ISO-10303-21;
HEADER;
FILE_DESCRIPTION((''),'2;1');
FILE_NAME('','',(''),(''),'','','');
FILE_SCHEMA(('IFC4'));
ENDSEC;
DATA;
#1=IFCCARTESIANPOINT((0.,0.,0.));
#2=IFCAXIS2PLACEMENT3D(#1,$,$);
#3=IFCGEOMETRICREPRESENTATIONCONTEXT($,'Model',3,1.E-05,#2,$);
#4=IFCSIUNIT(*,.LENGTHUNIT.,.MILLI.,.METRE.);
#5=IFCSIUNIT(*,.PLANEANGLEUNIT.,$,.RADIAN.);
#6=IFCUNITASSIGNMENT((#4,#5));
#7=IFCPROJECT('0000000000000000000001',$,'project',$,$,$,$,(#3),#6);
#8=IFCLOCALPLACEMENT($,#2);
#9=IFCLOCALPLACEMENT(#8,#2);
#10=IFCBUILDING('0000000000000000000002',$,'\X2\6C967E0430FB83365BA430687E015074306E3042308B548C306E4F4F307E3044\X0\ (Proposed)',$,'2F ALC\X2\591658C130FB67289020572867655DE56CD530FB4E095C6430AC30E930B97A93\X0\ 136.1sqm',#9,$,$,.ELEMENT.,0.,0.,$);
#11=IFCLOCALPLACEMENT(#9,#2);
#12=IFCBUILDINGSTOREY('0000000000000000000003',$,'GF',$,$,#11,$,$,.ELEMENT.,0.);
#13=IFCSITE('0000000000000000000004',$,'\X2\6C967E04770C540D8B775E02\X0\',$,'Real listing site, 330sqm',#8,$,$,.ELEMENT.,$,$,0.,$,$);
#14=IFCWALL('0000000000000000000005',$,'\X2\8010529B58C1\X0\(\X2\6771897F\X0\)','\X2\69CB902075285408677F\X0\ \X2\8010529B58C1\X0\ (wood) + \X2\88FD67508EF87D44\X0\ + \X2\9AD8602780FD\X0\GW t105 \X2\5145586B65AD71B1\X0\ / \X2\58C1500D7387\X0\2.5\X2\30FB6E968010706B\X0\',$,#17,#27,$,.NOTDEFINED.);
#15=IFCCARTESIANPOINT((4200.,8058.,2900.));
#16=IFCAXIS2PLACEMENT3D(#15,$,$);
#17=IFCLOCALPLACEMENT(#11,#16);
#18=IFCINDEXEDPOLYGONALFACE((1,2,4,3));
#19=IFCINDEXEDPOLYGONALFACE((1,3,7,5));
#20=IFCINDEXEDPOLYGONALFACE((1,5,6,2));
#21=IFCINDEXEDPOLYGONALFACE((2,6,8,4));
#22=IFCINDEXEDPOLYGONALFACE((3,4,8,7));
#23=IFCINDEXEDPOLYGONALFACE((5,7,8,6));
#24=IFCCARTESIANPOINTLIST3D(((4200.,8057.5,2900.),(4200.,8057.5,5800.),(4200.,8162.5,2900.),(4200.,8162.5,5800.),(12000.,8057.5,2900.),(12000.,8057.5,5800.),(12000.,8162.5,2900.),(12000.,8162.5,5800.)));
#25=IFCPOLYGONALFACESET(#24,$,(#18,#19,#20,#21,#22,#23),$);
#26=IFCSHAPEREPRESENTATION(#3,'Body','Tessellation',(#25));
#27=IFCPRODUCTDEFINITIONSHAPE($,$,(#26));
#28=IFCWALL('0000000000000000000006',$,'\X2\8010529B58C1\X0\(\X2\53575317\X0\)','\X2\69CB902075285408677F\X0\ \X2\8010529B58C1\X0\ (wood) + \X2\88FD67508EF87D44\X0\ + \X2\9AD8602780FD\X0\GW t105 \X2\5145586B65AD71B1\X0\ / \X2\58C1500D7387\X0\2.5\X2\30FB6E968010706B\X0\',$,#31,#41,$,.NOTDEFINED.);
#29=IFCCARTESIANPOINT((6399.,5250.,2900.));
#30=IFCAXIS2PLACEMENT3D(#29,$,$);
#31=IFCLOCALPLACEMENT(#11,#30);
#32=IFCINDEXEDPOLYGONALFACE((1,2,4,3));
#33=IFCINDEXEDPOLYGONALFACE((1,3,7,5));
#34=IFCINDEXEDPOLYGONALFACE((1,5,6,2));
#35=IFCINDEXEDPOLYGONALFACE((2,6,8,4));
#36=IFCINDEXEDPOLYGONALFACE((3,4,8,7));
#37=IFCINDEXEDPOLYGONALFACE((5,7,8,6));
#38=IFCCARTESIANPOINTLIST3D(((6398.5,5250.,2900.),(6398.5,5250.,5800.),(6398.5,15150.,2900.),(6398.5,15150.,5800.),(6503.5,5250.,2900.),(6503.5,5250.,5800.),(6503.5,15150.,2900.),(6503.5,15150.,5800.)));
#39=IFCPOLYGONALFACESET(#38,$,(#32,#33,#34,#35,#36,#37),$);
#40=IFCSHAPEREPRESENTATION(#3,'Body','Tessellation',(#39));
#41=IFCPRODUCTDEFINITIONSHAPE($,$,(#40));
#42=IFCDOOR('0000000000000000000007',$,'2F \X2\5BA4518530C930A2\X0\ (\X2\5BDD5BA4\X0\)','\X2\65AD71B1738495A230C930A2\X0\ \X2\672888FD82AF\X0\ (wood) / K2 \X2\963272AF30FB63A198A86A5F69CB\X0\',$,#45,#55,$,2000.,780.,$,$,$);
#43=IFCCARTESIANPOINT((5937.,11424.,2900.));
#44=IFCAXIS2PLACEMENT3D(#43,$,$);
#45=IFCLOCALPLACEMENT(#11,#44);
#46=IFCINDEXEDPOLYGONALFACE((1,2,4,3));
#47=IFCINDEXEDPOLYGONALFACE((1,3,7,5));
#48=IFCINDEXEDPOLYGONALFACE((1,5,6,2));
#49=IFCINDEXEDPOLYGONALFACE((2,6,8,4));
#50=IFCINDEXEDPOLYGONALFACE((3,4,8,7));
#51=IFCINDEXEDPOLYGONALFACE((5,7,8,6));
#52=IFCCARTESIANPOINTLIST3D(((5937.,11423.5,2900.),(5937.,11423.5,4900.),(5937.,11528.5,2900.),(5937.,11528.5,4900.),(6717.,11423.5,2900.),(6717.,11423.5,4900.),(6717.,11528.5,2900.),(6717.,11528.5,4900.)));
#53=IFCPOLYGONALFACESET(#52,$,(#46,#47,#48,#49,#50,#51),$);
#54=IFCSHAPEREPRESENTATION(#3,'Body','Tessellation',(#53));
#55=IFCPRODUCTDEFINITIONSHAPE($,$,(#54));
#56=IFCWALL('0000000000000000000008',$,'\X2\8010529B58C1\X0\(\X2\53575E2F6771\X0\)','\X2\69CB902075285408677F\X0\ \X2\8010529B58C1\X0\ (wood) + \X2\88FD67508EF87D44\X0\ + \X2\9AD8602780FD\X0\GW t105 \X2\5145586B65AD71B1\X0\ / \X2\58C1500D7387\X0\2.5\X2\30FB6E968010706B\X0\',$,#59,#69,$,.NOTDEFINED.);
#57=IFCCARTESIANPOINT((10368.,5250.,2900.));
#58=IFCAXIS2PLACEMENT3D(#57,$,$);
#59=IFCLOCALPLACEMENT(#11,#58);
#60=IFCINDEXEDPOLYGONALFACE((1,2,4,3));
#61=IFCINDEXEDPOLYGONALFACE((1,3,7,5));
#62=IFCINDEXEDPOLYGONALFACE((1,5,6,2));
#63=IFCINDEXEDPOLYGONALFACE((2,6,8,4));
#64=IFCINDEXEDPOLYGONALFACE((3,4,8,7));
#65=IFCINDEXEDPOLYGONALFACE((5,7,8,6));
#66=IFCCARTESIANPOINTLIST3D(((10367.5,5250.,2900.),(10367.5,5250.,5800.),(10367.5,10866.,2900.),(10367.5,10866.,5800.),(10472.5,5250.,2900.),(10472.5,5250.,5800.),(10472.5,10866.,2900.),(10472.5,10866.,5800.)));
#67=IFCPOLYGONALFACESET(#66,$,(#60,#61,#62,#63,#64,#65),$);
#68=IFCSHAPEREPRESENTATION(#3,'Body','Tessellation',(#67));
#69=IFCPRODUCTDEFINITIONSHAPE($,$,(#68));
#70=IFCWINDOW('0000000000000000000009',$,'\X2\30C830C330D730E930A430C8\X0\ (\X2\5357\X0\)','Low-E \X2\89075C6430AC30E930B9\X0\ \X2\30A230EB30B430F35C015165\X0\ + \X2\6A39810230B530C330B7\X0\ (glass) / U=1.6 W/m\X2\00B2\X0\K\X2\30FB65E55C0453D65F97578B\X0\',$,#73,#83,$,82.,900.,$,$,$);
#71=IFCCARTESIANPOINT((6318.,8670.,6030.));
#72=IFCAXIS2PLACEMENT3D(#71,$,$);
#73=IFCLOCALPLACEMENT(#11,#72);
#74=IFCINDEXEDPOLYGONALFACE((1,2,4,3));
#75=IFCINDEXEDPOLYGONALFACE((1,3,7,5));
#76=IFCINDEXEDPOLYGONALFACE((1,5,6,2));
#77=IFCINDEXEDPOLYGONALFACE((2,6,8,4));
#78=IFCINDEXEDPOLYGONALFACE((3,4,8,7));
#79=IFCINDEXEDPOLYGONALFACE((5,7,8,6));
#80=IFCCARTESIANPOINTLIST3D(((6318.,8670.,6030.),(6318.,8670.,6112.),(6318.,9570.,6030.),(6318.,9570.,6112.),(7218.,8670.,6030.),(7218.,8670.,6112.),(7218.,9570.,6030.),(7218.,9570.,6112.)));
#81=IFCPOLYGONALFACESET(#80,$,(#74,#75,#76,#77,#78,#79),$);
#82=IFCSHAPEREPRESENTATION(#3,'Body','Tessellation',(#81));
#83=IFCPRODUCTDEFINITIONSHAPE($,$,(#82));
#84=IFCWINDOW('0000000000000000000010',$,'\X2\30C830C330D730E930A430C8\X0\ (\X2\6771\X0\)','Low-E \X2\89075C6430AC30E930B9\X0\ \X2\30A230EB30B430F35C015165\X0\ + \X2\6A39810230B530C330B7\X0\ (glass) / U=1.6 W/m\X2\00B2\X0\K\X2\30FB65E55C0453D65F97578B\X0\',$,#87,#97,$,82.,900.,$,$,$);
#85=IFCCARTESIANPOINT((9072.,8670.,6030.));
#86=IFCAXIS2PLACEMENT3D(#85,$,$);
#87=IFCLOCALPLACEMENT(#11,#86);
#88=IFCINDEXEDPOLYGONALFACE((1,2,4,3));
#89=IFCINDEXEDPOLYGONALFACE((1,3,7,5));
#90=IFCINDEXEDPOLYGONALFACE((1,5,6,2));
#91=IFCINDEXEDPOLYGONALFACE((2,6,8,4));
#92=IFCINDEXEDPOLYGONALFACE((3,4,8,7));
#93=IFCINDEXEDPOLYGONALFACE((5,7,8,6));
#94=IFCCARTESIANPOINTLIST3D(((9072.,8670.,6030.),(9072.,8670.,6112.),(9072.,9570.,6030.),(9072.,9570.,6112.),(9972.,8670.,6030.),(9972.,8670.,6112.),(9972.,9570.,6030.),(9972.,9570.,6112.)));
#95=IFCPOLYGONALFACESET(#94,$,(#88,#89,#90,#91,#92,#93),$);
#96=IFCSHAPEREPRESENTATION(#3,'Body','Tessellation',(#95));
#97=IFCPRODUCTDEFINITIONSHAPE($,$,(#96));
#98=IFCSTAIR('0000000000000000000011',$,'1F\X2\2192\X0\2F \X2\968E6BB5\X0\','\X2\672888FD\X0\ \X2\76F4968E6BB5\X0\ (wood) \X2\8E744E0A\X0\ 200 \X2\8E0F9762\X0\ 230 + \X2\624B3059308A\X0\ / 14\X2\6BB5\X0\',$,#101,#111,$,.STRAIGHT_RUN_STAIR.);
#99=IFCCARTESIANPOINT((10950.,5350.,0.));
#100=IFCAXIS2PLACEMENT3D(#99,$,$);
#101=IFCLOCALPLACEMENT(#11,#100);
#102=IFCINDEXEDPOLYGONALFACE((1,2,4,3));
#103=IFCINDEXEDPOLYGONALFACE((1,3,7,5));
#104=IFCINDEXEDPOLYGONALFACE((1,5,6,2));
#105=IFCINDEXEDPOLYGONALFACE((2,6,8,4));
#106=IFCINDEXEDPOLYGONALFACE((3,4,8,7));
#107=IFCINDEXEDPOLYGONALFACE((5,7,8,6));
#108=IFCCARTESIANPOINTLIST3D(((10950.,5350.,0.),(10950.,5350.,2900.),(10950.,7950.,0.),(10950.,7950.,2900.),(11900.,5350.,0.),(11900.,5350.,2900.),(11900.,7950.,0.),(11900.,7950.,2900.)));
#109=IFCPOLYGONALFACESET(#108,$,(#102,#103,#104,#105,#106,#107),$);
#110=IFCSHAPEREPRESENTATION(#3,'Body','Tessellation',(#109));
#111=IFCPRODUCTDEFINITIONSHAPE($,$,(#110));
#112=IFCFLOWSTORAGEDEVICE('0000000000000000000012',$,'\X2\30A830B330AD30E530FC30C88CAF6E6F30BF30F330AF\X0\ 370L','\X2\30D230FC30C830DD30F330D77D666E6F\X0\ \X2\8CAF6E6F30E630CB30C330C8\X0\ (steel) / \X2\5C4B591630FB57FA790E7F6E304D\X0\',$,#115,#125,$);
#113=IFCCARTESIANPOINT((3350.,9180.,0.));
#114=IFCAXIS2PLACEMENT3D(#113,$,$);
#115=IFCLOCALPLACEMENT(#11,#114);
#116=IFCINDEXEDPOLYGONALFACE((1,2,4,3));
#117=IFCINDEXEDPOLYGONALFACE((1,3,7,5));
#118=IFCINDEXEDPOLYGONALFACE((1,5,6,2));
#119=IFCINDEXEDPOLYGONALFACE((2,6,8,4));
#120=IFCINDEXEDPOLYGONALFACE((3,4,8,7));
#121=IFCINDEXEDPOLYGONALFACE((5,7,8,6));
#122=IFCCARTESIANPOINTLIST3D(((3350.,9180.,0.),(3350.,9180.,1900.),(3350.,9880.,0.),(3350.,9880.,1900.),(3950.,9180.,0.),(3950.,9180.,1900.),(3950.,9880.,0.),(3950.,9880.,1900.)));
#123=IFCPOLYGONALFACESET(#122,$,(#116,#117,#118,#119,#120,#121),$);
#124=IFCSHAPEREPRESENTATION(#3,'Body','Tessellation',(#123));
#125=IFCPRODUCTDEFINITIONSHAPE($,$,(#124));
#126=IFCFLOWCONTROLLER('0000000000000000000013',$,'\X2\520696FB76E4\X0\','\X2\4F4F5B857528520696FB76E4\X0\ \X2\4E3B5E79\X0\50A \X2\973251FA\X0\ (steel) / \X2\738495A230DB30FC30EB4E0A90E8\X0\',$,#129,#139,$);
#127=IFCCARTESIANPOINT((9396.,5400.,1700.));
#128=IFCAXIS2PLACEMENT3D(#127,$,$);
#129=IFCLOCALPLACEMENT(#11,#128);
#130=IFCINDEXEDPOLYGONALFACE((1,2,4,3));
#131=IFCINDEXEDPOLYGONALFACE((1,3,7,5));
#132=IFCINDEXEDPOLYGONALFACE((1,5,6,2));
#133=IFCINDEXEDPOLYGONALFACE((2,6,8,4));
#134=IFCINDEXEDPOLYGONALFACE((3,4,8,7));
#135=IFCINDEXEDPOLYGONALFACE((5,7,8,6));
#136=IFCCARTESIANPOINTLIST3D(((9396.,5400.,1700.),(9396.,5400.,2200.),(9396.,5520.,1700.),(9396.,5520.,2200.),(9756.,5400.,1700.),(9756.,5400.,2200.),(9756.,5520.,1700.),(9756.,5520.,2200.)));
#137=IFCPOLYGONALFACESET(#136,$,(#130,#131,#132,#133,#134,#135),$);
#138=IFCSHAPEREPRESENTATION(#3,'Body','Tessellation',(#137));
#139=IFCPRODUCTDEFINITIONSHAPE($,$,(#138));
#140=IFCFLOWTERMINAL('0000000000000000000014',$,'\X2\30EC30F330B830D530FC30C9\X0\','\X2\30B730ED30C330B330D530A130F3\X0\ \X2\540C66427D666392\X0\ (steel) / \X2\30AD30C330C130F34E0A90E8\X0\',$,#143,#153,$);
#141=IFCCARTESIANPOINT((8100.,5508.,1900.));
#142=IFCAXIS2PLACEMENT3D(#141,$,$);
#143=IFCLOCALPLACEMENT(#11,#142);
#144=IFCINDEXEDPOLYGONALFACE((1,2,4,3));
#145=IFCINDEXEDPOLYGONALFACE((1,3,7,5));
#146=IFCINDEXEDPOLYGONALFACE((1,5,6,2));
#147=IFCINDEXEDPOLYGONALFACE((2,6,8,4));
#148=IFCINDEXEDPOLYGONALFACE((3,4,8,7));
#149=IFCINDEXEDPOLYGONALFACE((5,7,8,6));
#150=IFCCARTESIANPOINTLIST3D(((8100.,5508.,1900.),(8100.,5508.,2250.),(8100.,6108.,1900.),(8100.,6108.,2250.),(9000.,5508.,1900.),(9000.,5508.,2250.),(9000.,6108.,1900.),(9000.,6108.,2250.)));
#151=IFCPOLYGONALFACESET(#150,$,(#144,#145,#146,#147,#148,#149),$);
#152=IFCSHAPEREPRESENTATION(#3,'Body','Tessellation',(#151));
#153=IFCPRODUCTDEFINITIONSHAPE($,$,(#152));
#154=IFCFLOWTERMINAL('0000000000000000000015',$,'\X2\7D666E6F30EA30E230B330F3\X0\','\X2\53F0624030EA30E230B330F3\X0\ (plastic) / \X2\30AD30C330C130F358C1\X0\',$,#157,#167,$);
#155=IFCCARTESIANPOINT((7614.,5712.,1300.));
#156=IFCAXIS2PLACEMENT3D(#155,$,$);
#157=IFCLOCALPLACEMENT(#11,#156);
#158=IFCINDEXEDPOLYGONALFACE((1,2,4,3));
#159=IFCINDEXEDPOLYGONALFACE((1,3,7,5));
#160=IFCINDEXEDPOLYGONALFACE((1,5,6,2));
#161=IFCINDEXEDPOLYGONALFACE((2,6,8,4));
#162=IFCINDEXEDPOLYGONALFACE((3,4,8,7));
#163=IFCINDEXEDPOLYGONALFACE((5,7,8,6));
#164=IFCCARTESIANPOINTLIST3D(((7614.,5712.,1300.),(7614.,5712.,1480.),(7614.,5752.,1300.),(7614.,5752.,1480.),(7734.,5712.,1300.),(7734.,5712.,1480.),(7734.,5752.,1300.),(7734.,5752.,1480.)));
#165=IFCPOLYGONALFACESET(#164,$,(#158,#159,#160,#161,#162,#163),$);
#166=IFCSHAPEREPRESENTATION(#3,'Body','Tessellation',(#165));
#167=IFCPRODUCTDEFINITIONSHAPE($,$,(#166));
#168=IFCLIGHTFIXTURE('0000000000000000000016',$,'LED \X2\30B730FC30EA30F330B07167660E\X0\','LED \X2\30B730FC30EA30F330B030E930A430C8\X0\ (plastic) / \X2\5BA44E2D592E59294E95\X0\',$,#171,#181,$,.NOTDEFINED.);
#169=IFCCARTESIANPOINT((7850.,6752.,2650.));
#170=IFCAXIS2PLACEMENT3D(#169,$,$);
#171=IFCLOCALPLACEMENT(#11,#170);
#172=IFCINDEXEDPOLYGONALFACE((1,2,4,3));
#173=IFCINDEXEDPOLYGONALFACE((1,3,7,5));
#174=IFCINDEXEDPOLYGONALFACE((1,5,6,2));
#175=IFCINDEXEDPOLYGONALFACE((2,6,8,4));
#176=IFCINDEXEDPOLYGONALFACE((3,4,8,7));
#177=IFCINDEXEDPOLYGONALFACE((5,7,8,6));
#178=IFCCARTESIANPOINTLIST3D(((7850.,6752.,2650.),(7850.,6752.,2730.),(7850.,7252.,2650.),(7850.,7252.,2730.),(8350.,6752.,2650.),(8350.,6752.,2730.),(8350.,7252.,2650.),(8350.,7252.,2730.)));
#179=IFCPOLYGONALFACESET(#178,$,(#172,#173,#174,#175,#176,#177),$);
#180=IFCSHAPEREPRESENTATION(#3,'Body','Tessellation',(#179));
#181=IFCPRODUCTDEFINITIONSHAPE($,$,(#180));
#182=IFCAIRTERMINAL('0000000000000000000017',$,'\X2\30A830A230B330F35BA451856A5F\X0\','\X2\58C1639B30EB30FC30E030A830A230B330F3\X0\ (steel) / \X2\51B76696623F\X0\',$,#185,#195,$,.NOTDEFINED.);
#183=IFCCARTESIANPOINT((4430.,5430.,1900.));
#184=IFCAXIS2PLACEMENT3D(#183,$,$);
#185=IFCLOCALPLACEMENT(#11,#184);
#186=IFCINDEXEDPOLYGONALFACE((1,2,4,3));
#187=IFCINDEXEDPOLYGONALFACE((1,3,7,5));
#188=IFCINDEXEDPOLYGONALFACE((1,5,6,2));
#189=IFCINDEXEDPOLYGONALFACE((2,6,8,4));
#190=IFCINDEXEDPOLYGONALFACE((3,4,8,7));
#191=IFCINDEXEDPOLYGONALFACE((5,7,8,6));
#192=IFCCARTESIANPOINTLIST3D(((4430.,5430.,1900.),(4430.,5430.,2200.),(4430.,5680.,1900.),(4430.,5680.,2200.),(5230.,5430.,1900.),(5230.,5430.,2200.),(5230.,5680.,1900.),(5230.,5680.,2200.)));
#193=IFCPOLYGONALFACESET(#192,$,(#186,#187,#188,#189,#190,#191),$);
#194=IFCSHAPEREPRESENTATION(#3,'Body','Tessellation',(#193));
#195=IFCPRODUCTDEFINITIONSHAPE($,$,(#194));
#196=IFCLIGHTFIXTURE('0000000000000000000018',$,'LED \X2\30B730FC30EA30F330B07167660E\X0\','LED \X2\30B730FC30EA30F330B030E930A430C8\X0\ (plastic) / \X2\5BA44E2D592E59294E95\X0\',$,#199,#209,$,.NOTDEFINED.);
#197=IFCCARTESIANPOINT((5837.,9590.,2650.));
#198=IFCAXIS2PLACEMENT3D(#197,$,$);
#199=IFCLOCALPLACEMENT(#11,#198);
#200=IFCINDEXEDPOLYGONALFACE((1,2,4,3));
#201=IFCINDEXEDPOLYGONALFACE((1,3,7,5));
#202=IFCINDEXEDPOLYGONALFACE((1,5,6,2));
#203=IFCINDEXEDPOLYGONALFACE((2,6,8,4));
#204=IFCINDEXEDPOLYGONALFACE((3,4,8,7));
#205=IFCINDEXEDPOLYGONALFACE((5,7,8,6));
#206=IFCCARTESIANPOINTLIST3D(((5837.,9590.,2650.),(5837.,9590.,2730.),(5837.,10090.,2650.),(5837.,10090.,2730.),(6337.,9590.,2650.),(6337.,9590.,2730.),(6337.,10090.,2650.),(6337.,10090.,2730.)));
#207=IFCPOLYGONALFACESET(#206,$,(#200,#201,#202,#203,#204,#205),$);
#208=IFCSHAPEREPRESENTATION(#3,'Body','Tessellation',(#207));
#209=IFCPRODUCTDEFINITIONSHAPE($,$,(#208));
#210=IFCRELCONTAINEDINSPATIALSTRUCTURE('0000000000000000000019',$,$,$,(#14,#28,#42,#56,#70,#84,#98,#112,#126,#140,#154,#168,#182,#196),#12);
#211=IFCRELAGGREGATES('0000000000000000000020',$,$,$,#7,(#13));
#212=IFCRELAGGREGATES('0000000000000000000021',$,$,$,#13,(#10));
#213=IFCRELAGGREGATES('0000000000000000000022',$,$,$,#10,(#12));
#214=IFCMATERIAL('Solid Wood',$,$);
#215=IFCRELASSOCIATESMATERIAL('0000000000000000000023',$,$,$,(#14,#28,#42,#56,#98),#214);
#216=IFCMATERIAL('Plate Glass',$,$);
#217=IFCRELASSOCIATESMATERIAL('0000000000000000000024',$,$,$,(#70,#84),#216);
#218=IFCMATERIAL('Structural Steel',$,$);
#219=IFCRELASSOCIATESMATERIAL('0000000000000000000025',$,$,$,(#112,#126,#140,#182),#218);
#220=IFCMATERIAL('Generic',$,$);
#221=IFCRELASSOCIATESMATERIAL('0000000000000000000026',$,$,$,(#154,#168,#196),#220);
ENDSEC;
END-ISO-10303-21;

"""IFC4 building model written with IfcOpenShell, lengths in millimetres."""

from ifc_helpers import new_model, si_unit, frame, frame_2d, origin, place, context, project, spatial, rectangle, extrude, material, element, fill, save


model = new_model("IFC4")

# Units and contexts
model_context = context("Model", 3, precision=1e-05, world=origin())
ifc_project = project(units=[si_unit("LENGTHUNIT", "METRE", prefix="MILLI"), si_unit("PLANEANGLEUNIT", "RADIAN")], contexts=[model_context])

# Site, building, storey
site_placement = place(None, origin())
site = spatial("IfcSite", under=ifc_project, at=site_placement, Name="沖縄県名護市", ObjectType="Real listing site, 330sqm", CompositionType="ELEMENT", RefElevation=0.0)
building_placement = place(site_placement, origin())
building = spatial("IfcBuilding", under=site, at=building_placement, Name="沖縄・茶室と縁側のある和の住まい (Proposed)", ObjectType="2F ALC外壁・木造在来工法・三層ガラス窓 136.1sqm", CompositionType="ELEMENT", ElevationOfRefHeight=0.0, ElevationOfTerrain=0.0)
storey_placement = place(building_placement, origin())
storey = spatial("IfcBuildingStorey", under=building, at=storey_placement, Name="GF", CompositionType="ELEMENT", Elevation=0.0)

# Shared definitions
ifc_material_1 = material(Name="Solid Wood")

# Wall
wall_1_placement = place(storey_placement, frame((4200.0, 8058.0, 2900.0)))
element("IfcWall", 1, at=wall_1_placement, inside=storey, material=ifc_material_1, Name="耐力壁(東西)", Description="構造用合板 耐力壁 (wood) + 製材軸組 + 高性能GW t105 充填断熱 / 壁倍率2.5・準耐火", PredefinedType="NOTDEFINED", context=model_context, shape_type="SweptSolid", body=[
    extrude(rectangle(XDim=7800.0, YDim=105.0, at=frame_2d((3900.0, 52.0))), frame((4200.0, 8058.0, 2900.0)), (0.0, 0.0, 1.0), 2900.0),
])

# Wall, opening, door
wall_2_placement = place(storey_placement, frame((6399.0, 5250.0, 2900.0)))
wall_2 = element("IfcWall", 2, at=wall_2_placement, inside=storey, material=ifc_material_1, Name="耐力壁(南北)", Description="構造用合板 耐力壁 (wood) + 製材軸組 + 高性能GW t105 充填断熱 / 壁倍率2.5・準耐火", PredefinedType="NOTDEFINED", context=model_context, shape_type="SweptSolid", body=[
    extrude(rectangle(XDim=105.0, YDim=9900.0, at=frame_2d((52.0, 4950.0))), frame((6399.0, 5250.0, 2900.0)), (0.0, 0.0, 1.0), 2900.0),
])
opening_placement = place(storey_placement, frame((5937.0, 11424.0, 2900.0)))
opening = element("IfcOpeningElement", 3, at=opening_placement, cuts=wall_2, PredefinedType="NOTDEFINED", context=model_context, shape_type="SweptSolid", body=[
    extrude(rectangle(XDim=780.0, YDim=105.0, at=frame_2d((390.0, 52.0))), frame((5937.0, 11424.0, 2900.0)), (0.0, 0.0, 1.0), 2000.0),
])
door_placement = place(storey_placement, frame((5937.0, 11424.0, 2900.0)))
door = element("IfcDoor", 4, at=door_placement, inside=storey, material=ifc_material_1, Name="2F 室内ドア (寝室)", Description="断熱玄関ドア 木製芯 (wood) / K2 防犯・採風機構", OverallHeight=2000.0, OverallWidth=780.0, context=model_context, shape_type="SweptSolid", body=[
    extrude(rectangle(XDim=780.0, YDim=105.0, at=frame_2d((390.0, 52.0))), frame((5937.0, 11424.0, 2900.0)), (0.0, 0.0, 1.0), 2000.0),
])
fill(opening, door)

# Wall
wall_3_placement = place(storey_placement, frame((10368.0, 5250.0, 2900.0)))
element("IfcWall", 5, at=wall_3_placement, inside=storey, material=ifc_material_1, Name="耐力壁(南帯東)", Description="構造用合板 耐力壁 (wood) + 製材軸組 + 高性能GW t105 充填断熱 / 壁倍率2.5・準耐火", PredefinedType="NOTDEFINED", context=model_context, shape_type="SweptSolid", body=[
    extrude(rectangle(XDim=105.0, YDim=5616.0, at=frame_2d((52.0, 2808.0))), frame((10368.0, 5250.0, 2900.0)), (0.0, 0.0, 1.0), 2900.0),
])

# Windows
ifc_material_2 = material(Name="Plate Glass")
window_1_placement = place(storey_placement, frame((6318.0, 8670.0, 6030.0)))
element("IfcWindow", 6, at=window_1_placement, inside=storey, material=ifc_material_2, Name="トップライト (南)", Description="Low-E 複層ガラス アルゴン封入 + 樹脂サッシ (glass) / U=1.6 W/m²K・日射取得型", OverallHeight=82.0, OverallWidth=900.0, context=model_context, shape_type="SweptSolid", body=[
    extrude(rectangle(XDim=900.0, YDim=900.0, at=frame_2d((450.0, 450.0))), frame((6318.0, 8670.0, 6030.0)), (0.0, 0.0, 1.0), 82.0),
])
window_2_placement = place(storey_placement, frame((9072.0, 8670.0, 6030.0)))
element("IfcWindow", 7, at=window_2_placement, inside=storey, material=ifc_material_2, Name="トップライト (東)", Description="Low-E 複層ガラス アルゴン封入 + 樹脂サッシ (glass) / U=1.6 W/m²K・日射取得型", OverallHeight=82.0, OverallWidth=900.0, context=model_context, shape_type="SweptSolid", body=[
    extrude(rectangle(XDim=900.0, YDim=900.0, at=frame_2d((450.0, 450.0))), frame((9072.0, 8670.0, 6030.0)), (0.0, 0.0, 1.0), 82.0),
])

# Stair
stair_placement = place(storey_placement, frame((10950.0, 5350.0, 0.0)))
element("IfcStair", 8, at=stair_placement, inside=storey, material=ifc_material_1, Name="1F→2F 階段", Description="木製 直階段 (wood) 蹴上 200 踏面 230 + 手すり / 14段", PredefinedType="STRAIGHT_RUN_STAIR", context=model_context, shape_type="SweptSolid", body=[
    extrude(rectangle(XDim=950.0, YDim=2600.0, at=frame_2d((475.0, 1300.0))), frame((10950.0, 5350.0, 0.0)), (0.0, 0.0, 1.0), 2900.0),
])

# Flow storage device
ifc_material_3 = material(Name="Structural Steel")
flow_storage_device_placement = place(storey_placement, frame((3350.0, 9180.0, 0.0)))
element("IfcFlowStorageDevice", 9, at=flow_storage_device_placement, inside=storey, material=ifc_material_3, Name="エコキュート貯湯タンク 370L", Description="ヒートポンプ給湯 貯湯ユニット (steel) / 屋外・基礎置き", context=model_context, shape_type="SweptSolid", body=[
    extrude(rectangle(XDim=600.0, YDim=700.0, at=frame_2d((300.0, 350.0))), frame((3350.0, 9180.0, 0.0)), (0.0, 0.0, 1.0), 1900.0),
])

# Flow controller
flow_controller_placement = place(storey_placement, frame((9396.0, 5400.0, 1700.0)))
element("IfcFlowController", 10, at=flow_controller_placement, inside=storey, material=ifc_material_3, Name="分電盤", Description="住宅用分電盤 主幹50A 露出 (steel) / 玄関ホール上部", context=model_context, shape_type="SweptSolid", body=[
    extrude(rectangle(XDim=360.0, YDim=120.0, at=frame_2d((180.0, 60.0))), frame((9396.0, 5400.0, 1700.0)), (0.0, 0.0, 1.0), 500.0),
])

# Flow terminals
flow_terminal_1_placement = place(storey_placement, frame((8100.0, 5508.0, 1900.0)))
element("IfcFlowTerminal", 11, at=flow_terminal_1_placement, inside=storey, material=ifc_material_3, Name="レンジフード", Description="シロッコファン 同時給排 (steel) / キッチン上部", context=model_context, shape_type="SweptSolid", body=[
    extrude(rectangle(XDim=900.0, YDim=600.0, at=frame_2d((450.0, 300.0))), frame((8100.0, 5508.0, 1900.0)), (0.0, 0.0, 1.0), 350.0),
])
ifc_material_4 = material(Name="Generic")
flow_terminal_2_placement = place(storey_placement, frame((7614.0, 5712.0, 1300.0)))
element("IfcFlowTerminal", 12, at=flow_terminal_2_placement, inside=storey, material=ifc_material_4, Name="給湯リモコン", Description="台所リモコン (plastic) / キッチン壁", context=model_context, shape_type="SweptSolid", body=[
    extrude(rectangle(XDim=120.0, YDim=40.0, at=frame_2d((60.0, 20.0))), frame((7614.0, 5712.0, 1300.0)), (0.0, 0.0, 1.0), 180.0),
])

# Light fixture
light_fixture_1_placement = place(storey_placement, frame((7850.0, 6752.0, 2650.0)))
element("IfcLightFixture", 13, at=light_fixture_1_placement, inside=storey, material=ifc_material_4, Name="LED シーリング照明", Description="LED シーリングライト (plastic) / 室中央天井", PredefinedType="NOTDEFINED", context=model_context, shape_type="SweptSolid", body=[
    extrude(rectangle(XDim=500.0, YDim=500.0, at=frame_2d((250.0, 250.0))), frame((7850.0, 6752.0, 2650.0)), (0.0, 0.0, 1.0), 80.0),
])

# Air terminal
air_terminal_1_placement = place(storey_placement, frame((4430.0, 5430.0, 1900.0)))
element("IfcAirTerminal", 14, at=air_terminal_1_placement, inside=storey, material=ifc_material_3, Name="エアコン室内機", Description="壁掛ルームエアコン (steel) / 冷暖房", PredefinedType="NOTDEFINED", context=model_context, shape_type="SweptSolid", body=[
    extrude(rectangle(XDim=800.0, YDim=250.0, at=frame_2d((400.0, 125.0))), frame((4430.0, 5430.0, 1900.0)), (0.0, 0.0, 1.0), 300.0),
])

# Light fixture
light_fixture_2_placement = place(storey_placement, frame((5837.0, 9590.0, 2650.0)))
element("IfcLightFixture", 15, at=light_fixture_2_placement, inside=storey, material=ifc_material_4, Name="LED シーリング照明", Description="LED シーリングライト (plastic) / 室中央天井", PredefinedType="NOTDEFINED", context=model_context, shape_type="SweptSolid", body=[
    extrude(rectangle(XDim=500.0, YDim=500.0, at=frame_2d((250.0, 250.0))), frame((5837.0, 9590.0, 2650.0)), (0.0, 0.0, 1.0), 80.0),
])

save(model, "model.ifc")
